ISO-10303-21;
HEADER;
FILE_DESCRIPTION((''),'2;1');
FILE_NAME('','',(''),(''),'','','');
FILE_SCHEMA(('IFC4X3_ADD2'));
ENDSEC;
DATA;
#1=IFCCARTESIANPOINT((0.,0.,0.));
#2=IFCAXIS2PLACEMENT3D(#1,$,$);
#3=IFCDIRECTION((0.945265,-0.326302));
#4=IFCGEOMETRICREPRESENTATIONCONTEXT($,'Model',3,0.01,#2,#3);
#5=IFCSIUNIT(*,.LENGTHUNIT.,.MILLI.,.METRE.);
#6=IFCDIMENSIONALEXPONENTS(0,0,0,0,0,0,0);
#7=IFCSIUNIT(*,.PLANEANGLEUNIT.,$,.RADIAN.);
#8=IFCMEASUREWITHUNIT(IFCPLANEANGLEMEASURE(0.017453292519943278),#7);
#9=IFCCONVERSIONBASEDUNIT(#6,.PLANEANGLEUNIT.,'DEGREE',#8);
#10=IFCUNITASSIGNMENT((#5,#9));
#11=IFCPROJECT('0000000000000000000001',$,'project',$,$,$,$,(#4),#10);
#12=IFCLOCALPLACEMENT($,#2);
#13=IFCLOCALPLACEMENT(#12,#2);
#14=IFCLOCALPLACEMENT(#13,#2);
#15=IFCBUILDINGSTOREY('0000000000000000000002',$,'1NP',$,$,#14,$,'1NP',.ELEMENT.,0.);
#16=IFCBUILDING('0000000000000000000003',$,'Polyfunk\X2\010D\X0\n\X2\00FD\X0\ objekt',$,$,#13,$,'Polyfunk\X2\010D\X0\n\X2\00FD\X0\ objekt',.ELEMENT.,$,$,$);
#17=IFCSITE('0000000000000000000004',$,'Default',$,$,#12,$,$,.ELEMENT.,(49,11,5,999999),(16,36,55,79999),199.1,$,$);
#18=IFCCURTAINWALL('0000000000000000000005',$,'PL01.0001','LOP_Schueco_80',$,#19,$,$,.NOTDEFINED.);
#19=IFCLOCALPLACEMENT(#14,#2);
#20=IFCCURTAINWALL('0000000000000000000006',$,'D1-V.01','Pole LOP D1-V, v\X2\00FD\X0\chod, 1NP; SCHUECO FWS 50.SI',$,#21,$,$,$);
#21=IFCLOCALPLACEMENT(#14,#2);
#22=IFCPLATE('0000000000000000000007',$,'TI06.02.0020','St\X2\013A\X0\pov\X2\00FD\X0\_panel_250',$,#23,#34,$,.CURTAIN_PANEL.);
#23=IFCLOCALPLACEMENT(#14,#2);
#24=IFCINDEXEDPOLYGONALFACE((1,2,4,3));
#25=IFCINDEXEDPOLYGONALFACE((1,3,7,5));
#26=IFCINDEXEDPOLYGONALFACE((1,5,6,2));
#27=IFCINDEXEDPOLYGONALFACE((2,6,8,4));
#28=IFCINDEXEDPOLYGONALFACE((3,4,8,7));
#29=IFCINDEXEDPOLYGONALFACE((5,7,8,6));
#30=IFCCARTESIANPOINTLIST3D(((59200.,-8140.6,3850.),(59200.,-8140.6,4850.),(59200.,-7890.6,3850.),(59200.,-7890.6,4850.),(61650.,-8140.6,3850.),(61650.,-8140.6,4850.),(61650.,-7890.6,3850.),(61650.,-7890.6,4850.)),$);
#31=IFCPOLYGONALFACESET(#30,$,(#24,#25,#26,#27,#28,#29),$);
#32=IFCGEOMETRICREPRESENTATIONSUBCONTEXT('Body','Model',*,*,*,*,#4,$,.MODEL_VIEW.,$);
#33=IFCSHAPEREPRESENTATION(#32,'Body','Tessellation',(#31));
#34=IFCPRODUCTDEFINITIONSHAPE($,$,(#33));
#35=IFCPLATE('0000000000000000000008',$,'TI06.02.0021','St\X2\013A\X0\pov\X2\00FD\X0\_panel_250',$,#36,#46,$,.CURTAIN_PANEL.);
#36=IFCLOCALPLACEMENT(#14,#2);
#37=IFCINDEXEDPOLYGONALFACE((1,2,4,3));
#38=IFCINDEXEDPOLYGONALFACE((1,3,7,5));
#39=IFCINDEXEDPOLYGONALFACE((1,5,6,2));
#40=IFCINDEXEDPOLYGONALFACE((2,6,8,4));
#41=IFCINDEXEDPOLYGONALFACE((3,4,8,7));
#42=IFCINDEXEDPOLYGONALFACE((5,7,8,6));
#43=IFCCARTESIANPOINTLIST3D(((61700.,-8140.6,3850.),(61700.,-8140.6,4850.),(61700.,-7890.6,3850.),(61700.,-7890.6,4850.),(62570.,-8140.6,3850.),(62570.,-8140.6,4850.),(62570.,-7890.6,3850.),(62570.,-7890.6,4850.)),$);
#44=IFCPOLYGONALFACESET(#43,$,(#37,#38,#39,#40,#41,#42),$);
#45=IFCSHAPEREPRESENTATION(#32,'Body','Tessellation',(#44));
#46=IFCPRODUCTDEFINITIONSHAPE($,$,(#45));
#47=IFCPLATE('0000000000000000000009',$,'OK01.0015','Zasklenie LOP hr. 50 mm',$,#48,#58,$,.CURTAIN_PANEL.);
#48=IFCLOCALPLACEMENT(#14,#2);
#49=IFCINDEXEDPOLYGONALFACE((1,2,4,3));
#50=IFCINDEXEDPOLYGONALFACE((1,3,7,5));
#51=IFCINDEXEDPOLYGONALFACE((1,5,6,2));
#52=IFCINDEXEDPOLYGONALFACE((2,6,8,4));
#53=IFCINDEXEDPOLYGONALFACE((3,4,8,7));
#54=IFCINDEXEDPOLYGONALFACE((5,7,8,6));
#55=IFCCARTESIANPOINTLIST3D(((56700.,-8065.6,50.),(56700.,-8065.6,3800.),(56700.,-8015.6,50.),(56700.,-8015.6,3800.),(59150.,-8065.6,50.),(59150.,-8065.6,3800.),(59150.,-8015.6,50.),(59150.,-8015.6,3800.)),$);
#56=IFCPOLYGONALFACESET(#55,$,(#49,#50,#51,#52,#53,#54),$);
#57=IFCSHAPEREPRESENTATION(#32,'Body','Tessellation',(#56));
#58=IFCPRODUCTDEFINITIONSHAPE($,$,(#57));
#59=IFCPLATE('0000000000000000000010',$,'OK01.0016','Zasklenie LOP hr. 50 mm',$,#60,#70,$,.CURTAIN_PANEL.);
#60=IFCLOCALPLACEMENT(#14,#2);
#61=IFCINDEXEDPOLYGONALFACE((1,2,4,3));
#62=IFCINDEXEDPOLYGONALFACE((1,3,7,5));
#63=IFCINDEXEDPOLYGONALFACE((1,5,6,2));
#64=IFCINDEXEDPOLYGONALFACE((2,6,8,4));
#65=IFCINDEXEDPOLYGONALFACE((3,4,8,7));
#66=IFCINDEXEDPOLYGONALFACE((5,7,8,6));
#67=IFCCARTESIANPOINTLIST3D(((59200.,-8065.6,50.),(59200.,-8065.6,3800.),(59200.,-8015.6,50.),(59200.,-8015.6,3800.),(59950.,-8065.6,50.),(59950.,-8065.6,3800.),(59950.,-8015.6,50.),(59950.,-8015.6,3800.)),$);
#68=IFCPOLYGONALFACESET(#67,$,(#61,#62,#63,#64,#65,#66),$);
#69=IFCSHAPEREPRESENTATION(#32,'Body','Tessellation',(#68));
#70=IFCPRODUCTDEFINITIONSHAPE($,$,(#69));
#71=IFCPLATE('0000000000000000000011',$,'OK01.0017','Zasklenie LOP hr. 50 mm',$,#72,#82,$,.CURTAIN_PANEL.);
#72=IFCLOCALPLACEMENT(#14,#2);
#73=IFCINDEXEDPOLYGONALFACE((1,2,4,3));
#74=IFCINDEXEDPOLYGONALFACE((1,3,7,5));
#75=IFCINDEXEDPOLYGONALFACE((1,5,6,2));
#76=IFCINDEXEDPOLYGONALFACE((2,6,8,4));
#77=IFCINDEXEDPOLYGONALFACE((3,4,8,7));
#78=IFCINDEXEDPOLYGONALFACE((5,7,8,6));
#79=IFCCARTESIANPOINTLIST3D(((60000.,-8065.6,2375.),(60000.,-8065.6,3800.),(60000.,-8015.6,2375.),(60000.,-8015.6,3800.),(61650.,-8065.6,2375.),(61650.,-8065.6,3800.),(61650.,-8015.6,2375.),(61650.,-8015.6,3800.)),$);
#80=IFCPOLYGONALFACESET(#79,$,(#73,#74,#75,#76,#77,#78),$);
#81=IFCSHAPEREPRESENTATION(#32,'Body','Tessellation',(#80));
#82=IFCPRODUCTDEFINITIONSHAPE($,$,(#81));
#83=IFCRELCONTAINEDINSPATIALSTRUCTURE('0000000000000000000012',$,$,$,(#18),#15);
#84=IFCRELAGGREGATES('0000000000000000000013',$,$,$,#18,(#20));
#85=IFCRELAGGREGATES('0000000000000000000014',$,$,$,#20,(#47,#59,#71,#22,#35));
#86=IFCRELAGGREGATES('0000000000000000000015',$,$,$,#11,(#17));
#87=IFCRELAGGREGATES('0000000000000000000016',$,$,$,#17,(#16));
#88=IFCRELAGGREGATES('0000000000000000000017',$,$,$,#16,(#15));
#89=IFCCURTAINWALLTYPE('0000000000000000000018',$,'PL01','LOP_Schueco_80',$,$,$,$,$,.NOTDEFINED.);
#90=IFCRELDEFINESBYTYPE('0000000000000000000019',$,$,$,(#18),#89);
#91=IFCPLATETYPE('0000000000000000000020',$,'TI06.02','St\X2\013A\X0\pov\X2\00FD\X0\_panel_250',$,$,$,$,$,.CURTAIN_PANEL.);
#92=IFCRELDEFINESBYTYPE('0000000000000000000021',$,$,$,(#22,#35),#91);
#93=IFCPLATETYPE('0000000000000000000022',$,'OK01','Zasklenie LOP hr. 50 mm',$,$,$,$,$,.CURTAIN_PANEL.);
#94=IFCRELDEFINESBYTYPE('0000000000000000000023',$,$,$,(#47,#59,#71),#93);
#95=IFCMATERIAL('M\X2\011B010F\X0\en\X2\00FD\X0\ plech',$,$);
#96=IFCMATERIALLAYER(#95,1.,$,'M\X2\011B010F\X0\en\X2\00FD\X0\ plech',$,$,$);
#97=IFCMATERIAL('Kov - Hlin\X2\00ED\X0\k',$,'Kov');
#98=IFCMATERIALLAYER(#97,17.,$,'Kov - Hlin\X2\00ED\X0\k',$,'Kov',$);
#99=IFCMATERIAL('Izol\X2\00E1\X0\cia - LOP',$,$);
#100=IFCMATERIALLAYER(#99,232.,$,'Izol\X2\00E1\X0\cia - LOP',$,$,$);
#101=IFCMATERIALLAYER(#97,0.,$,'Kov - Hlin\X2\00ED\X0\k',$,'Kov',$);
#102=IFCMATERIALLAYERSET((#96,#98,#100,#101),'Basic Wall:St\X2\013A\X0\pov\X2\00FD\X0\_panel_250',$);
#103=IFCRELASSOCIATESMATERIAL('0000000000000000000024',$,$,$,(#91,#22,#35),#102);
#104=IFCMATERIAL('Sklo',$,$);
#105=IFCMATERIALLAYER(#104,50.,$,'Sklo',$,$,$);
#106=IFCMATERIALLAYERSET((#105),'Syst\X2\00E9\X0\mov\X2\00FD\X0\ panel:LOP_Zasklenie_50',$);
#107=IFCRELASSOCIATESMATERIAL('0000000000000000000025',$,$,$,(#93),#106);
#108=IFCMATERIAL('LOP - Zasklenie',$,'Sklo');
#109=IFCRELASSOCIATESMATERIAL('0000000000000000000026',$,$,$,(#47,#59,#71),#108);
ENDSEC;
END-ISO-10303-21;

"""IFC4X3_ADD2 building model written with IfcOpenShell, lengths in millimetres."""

from ifc_helpers import new_model, entity, si_unit, converted_unit, direction, frame, frame_2d, origin, origin_2d_with_axis, place, context, subcontext, project, spatial, rectangle, extrude, source, transform, mapped, material, layer, layer_set, layer_usage, type_object, type_shapes, element, aggregate, save


model = new_model("IFC4X3_ADD2")

# Units and contexts
model_context = context("Model", 3, precision=0.01, world=origin(), true_north=direction((0.945265, -0.326302)))
body_context = subcontext(model_context, "Body", "Model", "MODEL_VIEW")
ifc_project = project(units=[si_unit("LENGTHUNIT", "METRE", prefix="MILLI"), converted_unit("PLANEANGLEUNIT", "DEGREE", entity("IfcPlaneAngleMeasure", 0.017453292519943278), si_unit("PLANEANGLEUNIT", "RADIAN"), dimensions=[0, 0, 0, 0, 0, 0, 0])], contexts=[model_context])

# Site, building, storey
site_placement = place(None, origin())
site = spatial("IfcSite", under=ifc_project, at=site_placement, Name="Default", CompositionType="ELEMENT", RefLatitude=(49, 11, 5, 999999), RefLongitude=(16, 36, 55, 79999), RefElevation=199.1)
building_placement = place(site_placement, origin())
building = spatial("IfcBuilding", under=site, at=building_placement, Name="Polyfunkčný objekt", LongName="Polyfunkčný objekt", CompositionType="ELEMENT")
storey_placement = place(building_placement, origin())
storey = spatial("IfcBuildingStorey", under=building, at=storey_placement, Name="1NP", LongName="1NP", CompositionType="ELEMENT", Elevation=0.0)

# Curtain walls, plates
curtain_wall_type = type_object("IfcCurtainWallType", Name="PL01", Description="LOP_Schueco_80", PredefinedType="NOTDEFINED")
curtain_wall_1_placement = place(storey_placement, origin())
curtain_wall_1 = element("IfcCurtainWall", 1, at=curtain_wall_1_placement, inside=storey, type_object=curtain_wall_type, Name="PL01.0001", Description="LOP_Schueco_80", PredefinedType="NOTDEFINED")
curtain_wall_2 = element("IfcCurtainWall", 2, Name="D1-V.01", Description="Pole LOP D1-V, východ, 1NP; SCHUECO FWS 50.SI")
aggregate(curtain_wall_1, [curtain_wall_2])
ifc_material_1 = material(Name="Měďený plech")
ifc_layer_1 = layer(ifc_material_1, 1.0, Name="Měďený plech")
ifc_material_2 = material(Name="Kov - Hliník", Category="Kov")
ifc_layer_2 = layer(ifc_material_2, 17.0, Name="Kov - Hliník", Category="Kov")
ifc_material_3 = material(Name="Izolácia - LOP")
ifc_layer_3 = layer(ifc_material_3, 232.0, Name="Izolácia - LOP")
ifc_layer_4 = layer(ifc_material_2, 0.0, Name="Kov - Hliník", Category="Kov")
ifc_layer_set_1 = layer_set([ifc_layer_1, ifc_layer_2, ifc_layer_3, ifc_layer_4], Name="Basic Wall:Stĺpový_panel_250")
ifc_layer_usage_1 = layer_usage(ifc_layer_set_1, "AXIS2", "POSITIVE", -125.0)
plate_type_1 = type_object("IfcPlateType", Name="TI06.02", Description="Stĺpový_panel_250", PredefinedType="CURTAIN_PANEL", material=ifc_layer_set_1)
plate_1_placement = place(storey_placement, frame((59200.0, -8015.6, 3850.0)))
plate_1 = element("IfcPlate", 3, at=plate_1_placement, type_object=plate_type_1, material=ifc_layer_usage_1, Name="TI06.02.0020", Description="Stĺpový_panel_250", PredefinedType="CURTAIN_PANEL", context=body_context, shape_type="SweptSolid", body=[
    extrude(rectangle(XDim=250.0, YDim=2450.0, at=origin_2d_with_axis()), frame((1225.0, 0.0, 0.0), z_axis=(0.0, 0.0, 1.0), x_axis=(0.0, 1.0, 0.0)), (0.0, 0.0, 1.0), 1000.0),
])
ifc_layer_usage_2 = layer_usage(ifc_layer_set_1, "AXIS2", "POSITIVE", -125.0)
plate_2_placement = place(storey_placement, frame((61700.0, -8015.6, 3850.0)))
plate_2 = element("IfcPlate", 4, at=plate_2_placement, type_object=plate_type_1, material=ifc_layer_usage_2, Name="TI06.02.0021", Description="Stĺpový_panel_250", PredefinedType="CURTAIN_PANEL", context=body_context, shape_type="SweptSolid", body=[
    extrude(rectangle(XDim=250.0, YDim=870.0, at=frame_2d((0.0, 0.0), x_axis=(1.0, 0.0))), frame((435.0, 0.0, 0.0), z_axis=(0.0, 0.0, 1.0), x_axis=(0.0, 1.0, 0.0)), (0.0, 0.0, 1.0), 1000.0),
])
ifc_material_4 = material(Name="LOP - Zasklenie", Category="Sklo")
ifc_material_5 = material(Name="Sklo")
ifc_layer_5 = layer(ifc_material_5, 50.0, Name="Sklo")
ifc_layer_set_2 = layer_set([ifc_layer_5], Name="Systémový panel:LOP_Zasklenie_50")
plate_type_2 = type_object("IfcPlateType", Name="OK01", Description="Zasklenie LOP hr. 50 mm", PredefinedType="CURTAIN_PANEL", material=ifc_layer_set_2)
shared_shape_1 = source(origin(), body_context, "Body", "SweptSolid", [
    extrude(rectangle(XDim=3750.0, YDim=2450.0, at=frame_2d((-331.2, 0.0), x_axis=(1.0, 0.0))), frame((0.0, -50.0, 2206.2), z_axis=(0.0, 1.0, 0.0), x_axis=(0.0, 0.0, 1.0)), (0.0, 0.0, 1.0), 50.0),
])
plate_3_placement = place(curtain_wall_1_placement, frame((57925.0, -8015.6, 50.0)))
plate_3 = element("IfcPlate", 5, at=plate_3_placement, type_object=plate_type_2, material=ifc_material_4, Name="OK01.0015", Description="Zasklenie LOP hr. 50 mm", PredefinedType="CURTAIN_PANEL", context=body_context, shape_type="MappedRepresentation", body=[
    mapped(shared_shape_1, transform((0.0, 0.0, 0.0), scale=1.0)),
])
shared_shape_2 = source(origin(), body_context, "Body", "SweptSolid", [
    extrude(rectangle(XDim=3750.0, YDim=750.0, at=frame_2d((-331.2, 0.0), x_axis=(1.0, 0.0))), frame((0.0, -50.0, 2206.2), z_axis=(0.0, 1.0, 0.0), x_axis=(0.0, 0.0, 1.0)), (0.0, 0.0, 1.0), 50.0),
])
plate_4_placement = place(curtain_wall_1_placement, frame((59575.0, -8015.6, 50.0)))
plate_4 = element("IfcPlate", 6, at=plate_4_placement, type_object=plate_type_2, material=ifc_material_4, Name="OK01.0016", Description="Zasklenie LOP hr. 50 mm", PredefinedType="CURTAIN_PANEL", context=body_context, shape_type="MappedRepresentation", body=[
    mapped(shared_shape_2, transform((0.0, 0.0, 0.0), scale=1.0)),
])
shared_shape_3 = source(origin(), body_context, "Body", "SweptSolid", [
    extrude(rectangle(XDim=1425.0, YDim=1650.0, at=frame_2d((87.6, 0.0), x_axis=(1.0, 0.0))), frame((0.0, -50.0, 624.9), z_axis=(0.0, 1.0, 0.0), x_axis=(0.0, 0.0, 1.0)), (0.0, 0.0, 1.0), 50.0),
])
type_shapes(plate_type_2, [shared_shape_1, shared_shape_2, shared_shape_3])
plate_5_placement = place(curtain_wall_1_placement, frame((60825.0, -8015.6, 2375.0)))
plate_5 = element("IfcPlate", 7, at=plate_5_placement, type_object=plate_type_2, material=ifc_material_4, Name="OK01.0017", Description="Zasklenie LOP hr. 50 mm", PredefinedType="CURTAIN_PANEL", context=body_context, shape_type="MappedRepresentation", body=[
    mapped(shared_shape_3, transform((0.0, 0.0, 0.0), scale=1.0)),
])
aggregate(curtain_wall_2, [plate_3, plate_4, plate_5, plate_1, plate_2])

save(model, "model.ifc")
